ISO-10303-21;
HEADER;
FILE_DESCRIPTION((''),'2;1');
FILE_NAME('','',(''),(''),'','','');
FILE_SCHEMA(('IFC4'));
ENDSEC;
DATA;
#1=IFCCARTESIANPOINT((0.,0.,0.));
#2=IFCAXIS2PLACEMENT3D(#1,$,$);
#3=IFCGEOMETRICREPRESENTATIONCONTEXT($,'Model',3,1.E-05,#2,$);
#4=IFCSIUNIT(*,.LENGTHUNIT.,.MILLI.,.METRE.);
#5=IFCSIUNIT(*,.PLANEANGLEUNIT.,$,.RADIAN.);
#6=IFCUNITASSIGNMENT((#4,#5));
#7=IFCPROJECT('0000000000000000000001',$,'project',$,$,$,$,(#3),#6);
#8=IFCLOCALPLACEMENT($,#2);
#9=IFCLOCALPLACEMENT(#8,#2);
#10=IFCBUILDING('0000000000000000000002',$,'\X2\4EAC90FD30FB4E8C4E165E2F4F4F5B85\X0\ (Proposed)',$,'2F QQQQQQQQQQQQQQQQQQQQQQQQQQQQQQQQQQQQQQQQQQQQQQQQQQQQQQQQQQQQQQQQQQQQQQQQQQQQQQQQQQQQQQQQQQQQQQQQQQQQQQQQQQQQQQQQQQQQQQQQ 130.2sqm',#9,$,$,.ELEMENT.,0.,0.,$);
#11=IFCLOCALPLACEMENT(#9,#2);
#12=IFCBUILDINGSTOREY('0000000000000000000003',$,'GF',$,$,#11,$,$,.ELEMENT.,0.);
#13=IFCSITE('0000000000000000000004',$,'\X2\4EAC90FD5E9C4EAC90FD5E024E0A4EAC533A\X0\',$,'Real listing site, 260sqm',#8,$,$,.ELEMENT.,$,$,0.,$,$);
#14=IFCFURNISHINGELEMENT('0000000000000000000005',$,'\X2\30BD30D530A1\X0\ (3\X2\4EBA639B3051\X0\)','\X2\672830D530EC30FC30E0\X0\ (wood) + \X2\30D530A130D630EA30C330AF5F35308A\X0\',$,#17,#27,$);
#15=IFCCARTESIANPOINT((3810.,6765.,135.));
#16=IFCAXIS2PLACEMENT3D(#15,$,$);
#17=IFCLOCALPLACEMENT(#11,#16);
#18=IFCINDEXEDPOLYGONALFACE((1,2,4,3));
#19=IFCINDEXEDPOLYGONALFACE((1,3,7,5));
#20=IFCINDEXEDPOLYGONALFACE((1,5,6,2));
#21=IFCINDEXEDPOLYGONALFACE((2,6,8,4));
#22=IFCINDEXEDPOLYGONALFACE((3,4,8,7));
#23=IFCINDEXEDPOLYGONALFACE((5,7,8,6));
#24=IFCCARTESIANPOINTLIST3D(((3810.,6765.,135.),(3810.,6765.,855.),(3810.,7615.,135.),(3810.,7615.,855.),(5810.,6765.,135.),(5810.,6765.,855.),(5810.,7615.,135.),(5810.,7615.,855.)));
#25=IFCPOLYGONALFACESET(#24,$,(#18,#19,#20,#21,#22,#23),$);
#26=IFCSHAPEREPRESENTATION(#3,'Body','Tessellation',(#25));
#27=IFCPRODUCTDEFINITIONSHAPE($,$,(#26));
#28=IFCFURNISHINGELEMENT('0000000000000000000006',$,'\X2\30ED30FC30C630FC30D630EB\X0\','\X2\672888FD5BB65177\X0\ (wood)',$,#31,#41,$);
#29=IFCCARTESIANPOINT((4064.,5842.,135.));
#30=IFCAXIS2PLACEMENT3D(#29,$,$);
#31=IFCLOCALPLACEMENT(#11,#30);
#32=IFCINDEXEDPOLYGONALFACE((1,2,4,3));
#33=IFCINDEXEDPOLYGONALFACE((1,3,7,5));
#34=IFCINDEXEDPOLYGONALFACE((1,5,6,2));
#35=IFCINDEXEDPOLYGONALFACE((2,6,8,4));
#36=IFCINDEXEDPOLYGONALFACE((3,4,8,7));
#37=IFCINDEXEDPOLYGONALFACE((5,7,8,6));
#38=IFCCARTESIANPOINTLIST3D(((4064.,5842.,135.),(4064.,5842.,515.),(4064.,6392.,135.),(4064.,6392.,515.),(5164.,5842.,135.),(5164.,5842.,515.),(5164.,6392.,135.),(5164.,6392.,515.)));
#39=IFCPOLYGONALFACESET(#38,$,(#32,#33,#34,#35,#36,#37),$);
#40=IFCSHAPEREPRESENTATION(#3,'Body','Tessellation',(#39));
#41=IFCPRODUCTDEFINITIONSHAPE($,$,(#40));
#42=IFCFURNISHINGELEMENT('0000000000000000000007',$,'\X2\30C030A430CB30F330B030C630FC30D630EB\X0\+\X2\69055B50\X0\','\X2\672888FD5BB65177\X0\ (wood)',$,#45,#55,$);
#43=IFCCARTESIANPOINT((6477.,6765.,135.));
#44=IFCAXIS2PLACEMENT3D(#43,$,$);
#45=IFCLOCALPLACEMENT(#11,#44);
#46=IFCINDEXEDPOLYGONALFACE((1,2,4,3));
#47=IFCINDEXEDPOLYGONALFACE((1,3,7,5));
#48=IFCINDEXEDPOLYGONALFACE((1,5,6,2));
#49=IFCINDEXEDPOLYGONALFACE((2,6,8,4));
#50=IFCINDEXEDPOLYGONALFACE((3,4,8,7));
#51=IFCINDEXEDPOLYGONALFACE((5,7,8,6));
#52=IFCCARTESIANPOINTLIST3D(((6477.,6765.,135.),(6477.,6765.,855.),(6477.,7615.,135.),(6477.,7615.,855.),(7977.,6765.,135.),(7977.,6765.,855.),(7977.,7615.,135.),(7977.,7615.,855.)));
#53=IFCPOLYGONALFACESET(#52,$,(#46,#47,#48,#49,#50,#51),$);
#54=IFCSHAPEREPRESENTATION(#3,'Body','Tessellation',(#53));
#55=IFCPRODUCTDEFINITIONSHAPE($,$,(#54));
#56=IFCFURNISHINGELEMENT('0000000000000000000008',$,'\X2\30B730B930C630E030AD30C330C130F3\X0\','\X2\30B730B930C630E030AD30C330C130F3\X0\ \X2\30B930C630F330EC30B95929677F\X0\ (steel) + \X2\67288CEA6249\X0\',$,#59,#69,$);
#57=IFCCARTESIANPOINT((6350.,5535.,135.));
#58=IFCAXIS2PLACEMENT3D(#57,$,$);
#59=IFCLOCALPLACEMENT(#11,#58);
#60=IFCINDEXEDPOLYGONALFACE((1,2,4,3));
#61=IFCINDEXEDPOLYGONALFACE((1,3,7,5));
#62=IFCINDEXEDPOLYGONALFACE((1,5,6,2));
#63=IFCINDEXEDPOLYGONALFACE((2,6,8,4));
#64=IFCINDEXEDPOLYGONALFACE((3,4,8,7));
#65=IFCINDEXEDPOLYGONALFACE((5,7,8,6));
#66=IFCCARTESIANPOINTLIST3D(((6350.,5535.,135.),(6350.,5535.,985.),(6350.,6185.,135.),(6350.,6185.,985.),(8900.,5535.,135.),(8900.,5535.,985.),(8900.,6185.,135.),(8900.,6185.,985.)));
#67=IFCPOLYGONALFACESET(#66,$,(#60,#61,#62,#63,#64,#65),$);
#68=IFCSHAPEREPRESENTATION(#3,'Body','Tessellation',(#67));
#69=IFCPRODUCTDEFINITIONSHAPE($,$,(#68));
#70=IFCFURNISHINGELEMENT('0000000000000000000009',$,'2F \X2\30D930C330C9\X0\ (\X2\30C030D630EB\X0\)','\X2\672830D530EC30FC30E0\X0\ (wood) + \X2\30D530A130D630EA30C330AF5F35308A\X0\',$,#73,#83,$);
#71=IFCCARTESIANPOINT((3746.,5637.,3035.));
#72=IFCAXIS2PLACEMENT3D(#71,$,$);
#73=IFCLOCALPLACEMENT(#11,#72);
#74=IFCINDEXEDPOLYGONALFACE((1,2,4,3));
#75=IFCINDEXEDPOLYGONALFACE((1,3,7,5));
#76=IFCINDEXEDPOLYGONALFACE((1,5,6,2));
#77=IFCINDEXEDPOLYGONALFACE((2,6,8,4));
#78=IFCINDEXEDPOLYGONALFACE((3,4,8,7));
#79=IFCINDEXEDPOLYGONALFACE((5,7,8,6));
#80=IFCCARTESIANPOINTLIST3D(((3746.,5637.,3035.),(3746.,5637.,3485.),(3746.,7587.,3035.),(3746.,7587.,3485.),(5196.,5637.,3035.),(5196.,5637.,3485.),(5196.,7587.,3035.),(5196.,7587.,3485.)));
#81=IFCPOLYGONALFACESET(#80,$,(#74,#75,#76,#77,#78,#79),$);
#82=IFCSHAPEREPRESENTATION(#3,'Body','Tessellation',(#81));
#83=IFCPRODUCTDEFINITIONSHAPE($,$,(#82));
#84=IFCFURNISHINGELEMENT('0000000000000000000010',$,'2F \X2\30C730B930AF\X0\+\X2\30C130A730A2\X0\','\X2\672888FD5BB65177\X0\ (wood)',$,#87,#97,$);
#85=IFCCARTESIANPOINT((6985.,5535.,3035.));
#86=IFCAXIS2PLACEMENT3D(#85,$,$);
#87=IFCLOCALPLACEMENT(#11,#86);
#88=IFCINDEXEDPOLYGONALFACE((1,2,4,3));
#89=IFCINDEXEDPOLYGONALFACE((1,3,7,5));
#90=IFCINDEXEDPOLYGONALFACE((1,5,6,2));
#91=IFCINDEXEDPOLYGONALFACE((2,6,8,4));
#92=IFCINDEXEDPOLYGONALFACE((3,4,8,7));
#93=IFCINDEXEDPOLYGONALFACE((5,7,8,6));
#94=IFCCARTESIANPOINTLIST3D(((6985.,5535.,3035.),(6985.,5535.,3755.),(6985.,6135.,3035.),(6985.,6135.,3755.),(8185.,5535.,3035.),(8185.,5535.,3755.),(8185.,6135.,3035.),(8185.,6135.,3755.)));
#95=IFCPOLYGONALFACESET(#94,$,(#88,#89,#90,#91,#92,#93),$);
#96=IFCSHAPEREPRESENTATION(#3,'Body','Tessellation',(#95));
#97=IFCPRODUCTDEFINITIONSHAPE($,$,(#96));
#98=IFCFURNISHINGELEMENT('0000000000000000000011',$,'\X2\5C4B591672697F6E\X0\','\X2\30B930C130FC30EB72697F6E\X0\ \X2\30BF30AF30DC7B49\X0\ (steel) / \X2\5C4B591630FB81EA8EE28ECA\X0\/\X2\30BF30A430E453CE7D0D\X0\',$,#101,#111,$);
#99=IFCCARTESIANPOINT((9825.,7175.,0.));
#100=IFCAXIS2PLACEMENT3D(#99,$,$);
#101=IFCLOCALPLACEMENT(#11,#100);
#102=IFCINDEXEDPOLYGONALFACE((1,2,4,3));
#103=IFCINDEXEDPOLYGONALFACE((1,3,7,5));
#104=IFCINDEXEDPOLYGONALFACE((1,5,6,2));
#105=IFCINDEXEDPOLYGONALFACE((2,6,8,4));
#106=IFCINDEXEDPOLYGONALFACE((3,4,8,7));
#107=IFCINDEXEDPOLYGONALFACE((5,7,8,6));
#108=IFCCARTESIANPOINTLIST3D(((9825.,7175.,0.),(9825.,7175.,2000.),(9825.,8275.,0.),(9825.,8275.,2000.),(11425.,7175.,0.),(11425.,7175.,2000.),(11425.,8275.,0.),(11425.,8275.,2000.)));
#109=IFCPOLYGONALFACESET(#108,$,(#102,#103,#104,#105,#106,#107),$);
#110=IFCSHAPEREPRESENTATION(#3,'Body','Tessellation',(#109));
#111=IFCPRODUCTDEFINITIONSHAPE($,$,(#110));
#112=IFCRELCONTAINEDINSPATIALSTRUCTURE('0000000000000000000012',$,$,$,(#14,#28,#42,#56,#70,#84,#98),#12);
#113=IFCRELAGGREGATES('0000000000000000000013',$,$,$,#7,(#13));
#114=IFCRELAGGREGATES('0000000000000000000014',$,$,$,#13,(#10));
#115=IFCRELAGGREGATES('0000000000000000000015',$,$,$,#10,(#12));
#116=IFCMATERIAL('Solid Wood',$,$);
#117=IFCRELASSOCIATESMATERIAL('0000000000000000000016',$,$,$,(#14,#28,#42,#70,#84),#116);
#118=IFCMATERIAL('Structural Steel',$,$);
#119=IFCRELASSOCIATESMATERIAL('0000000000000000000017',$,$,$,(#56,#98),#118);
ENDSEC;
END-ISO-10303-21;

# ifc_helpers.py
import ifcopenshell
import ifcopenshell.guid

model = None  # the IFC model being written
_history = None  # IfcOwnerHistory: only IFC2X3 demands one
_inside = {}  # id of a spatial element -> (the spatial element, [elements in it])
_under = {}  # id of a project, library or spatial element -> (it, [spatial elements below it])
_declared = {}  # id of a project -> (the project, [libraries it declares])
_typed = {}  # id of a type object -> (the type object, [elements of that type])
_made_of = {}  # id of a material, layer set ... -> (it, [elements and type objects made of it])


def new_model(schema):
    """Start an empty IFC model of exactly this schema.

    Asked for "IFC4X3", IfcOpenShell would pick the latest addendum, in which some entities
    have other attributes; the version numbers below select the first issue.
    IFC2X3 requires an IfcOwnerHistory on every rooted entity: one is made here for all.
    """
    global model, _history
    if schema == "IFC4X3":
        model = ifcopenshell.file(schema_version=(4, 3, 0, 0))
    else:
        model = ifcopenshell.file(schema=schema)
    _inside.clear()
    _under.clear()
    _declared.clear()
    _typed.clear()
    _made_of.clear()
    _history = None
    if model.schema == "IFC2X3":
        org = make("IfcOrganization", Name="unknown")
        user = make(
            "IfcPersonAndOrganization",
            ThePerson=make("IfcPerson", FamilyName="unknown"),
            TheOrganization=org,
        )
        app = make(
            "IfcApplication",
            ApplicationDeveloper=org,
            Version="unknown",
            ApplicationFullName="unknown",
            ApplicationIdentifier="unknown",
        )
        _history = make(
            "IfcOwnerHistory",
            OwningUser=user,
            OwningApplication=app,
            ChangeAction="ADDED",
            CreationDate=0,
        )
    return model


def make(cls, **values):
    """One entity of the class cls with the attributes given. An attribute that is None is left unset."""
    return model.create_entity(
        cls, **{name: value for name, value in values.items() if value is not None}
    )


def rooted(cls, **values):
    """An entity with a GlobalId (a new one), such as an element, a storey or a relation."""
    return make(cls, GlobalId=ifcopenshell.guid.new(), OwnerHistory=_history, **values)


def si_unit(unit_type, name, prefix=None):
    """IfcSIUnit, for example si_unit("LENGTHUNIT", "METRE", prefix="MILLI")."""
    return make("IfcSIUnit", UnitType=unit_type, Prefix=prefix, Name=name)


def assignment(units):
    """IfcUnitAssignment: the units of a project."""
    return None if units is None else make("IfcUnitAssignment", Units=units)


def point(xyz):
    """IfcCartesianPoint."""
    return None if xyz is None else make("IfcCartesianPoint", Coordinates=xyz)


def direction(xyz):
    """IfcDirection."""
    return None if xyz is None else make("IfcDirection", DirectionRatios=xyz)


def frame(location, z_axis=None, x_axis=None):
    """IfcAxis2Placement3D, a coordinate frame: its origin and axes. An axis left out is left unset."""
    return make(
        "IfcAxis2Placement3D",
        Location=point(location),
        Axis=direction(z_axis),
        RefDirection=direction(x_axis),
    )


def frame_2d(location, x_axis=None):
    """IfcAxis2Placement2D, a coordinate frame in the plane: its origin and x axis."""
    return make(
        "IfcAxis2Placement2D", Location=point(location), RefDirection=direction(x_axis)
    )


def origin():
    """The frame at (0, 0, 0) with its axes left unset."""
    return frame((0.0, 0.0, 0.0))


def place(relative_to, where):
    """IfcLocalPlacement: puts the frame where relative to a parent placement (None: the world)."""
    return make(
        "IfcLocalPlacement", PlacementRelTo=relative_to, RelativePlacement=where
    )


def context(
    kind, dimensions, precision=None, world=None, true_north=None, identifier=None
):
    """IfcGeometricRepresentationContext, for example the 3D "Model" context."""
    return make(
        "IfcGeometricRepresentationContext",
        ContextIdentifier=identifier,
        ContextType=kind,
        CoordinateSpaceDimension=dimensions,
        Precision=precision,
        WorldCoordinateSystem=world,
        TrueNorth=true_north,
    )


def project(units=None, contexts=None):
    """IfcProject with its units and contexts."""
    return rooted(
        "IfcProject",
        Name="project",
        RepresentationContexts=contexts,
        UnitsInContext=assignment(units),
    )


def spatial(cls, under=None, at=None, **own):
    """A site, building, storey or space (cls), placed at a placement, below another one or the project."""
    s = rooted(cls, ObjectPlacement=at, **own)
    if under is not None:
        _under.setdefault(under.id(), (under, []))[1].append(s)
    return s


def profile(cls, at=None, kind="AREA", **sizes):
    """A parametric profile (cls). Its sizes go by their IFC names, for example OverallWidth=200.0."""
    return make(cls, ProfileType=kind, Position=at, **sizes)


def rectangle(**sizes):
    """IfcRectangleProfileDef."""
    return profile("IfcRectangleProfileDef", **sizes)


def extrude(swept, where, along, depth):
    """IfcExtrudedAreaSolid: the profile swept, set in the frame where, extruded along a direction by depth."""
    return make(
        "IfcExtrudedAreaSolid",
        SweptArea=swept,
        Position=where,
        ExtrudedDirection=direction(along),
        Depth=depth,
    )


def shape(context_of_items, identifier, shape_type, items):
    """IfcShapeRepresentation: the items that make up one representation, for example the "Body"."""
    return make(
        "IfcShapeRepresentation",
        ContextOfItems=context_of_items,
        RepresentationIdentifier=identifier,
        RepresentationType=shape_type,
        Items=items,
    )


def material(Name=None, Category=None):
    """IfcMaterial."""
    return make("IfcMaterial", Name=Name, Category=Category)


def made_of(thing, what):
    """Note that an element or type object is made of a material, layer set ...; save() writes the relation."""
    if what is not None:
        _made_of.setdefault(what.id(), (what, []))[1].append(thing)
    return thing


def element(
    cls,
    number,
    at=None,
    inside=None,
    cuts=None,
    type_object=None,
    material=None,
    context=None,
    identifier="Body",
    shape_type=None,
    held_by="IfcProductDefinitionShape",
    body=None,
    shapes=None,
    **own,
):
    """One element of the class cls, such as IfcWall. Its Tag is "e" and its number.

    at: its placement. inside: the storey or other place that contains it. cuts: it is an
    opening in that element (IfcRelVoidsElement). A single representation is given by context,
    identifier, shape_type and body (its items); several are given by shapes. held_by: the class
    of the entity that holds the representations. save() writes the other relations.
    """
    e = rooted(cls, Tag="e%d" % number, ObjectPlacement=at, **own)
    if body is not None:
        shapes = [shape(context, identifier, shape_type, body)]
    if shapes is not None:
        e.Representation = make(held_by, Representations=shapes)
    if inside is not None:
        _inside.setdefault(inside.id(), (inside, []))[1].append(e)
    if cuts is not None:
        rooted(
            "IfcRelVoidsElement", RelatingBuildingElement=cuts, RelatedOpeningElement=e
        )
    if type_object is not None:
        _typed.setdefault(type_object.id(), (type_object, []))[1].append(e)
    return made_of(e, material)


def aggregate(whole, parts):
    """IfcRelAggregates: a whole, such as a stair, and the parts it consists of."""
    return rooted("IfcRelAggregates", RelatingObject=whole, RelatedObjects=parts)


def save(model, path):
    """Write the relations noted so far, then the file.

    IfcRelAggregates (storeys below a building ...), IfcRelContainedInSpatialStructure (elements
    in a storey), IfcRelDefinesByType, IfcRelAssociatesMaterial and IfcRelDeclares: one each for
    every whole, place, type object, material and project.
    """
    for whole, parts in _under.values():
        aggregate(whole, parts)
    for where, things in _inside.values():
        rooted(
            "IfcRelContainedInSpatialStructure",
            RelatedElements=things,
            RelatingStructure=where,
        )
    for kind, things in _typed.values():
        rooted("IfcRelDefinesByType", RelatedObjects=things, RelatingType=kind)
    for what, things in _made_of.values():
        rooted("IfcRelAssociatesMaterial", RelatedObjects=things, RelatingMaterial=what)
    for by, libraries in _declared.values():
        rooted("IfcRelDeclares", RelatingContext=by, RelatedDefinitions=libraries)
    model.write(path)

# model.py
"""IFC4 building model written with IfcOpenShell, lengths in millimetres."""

from ifc_helpers import new_model, si_unit, frame, frame_2d, origin, place, context, project, spatial, rectangle, extrude, material, element, save


model = new_model("IFC4")

# Units and contexts
model_context = context("Model", 3, precision=1e-05, world=origin())
ifc_project = project(units=[si_unit("LENGTHUNIT", "METRE", prefix="MILLI"), si_unit("PLANEANGLEUNIT", "RADIAN")], contexts=[model_context])

# Site, building, storey
site_placement = place(None, origin())
site = spatial("IfcSite", under=ifc_project, at=site_placement, Name="京都府京都市上京区", ObjectType="Real listing site, 260sqm", CompositionType="ELEMENT", RefElevation=0.0)
building_placement = place(site_placement, origin())
building = spatial("IfcBuilding", under=site, at=building_placement, Name="京都・二世帯住宅 (Proposed)", ObjectType="2F QQQQQQQQQQQQQQQQQQQQQQQQQQQQQQQQQQQQQQQQQQQQQQQQQQQQQQQQQQQQQQQQQQQQQQQQQQQQQQQQQQQQQQQQQQQQQQQQQQQQQQQQQQQQQQQQQQQQQQQQ 130.2sqm", CompositionType="ELEMENT", ElevationOfRefHeight=0.0, ElevationOfTerrain=0.0)
storey_placement = place(building_placement, origin())
storey = spatial("IfcBuildingStorey", under=building, at=storey_placement, Name="GF", CompositionType="ELEMENT", Elevation=0.0)

# Shared definitions
ifc_material_1 = material(Name="Solid Wood")

# Shared definitions
ifc_material_2 = material(Name="Structural Steel")

# Furnishing elements
furnishing_1_placement = place(storey_placement, frame((3810.0, 6765.0, 135.0)))
element("IfcFurnishingElement", 1, at=furnishing_1_placement, inside=storey, material=ifc_material_1, Name="ソファ (3人掛け)", Description="木フレーム (wood) + ファブリック張り", context=model_context, shape_type="SweptSolid", body=[
    extrude(rectangle(XDim=2000.0, YDim=850.0, at=frame_2d((1000.0, 425.0))), frame((3810.0, 6765.0, 135.0)), (0.0, 0.0, 1.0), 720.0),
])
furnishing_2_placement = place(storey_placement, frame((4064.0, 5842.0, 135.0)))
element("IfcFurnishingElement", 2, at=furnishing_2_placement, inside=storey, material=ifc_material_1, Name="ローテーブル", Description="木製家具 (wood)", context=model_context, shape_type="SweptSolid", body=[
    extrude(rectangle(XDim=1100.0, YDim=550.0, at=frame_2d((550.0, 275.0))), frame((4064.0, 5842.0, 135.0)), (0.0, 0.0, 1.0), 380.0),
])
furnishing_3_placement = place(storey_placement, frame((6477.0, 6765.0, 135.0)))
element("IfcFurnishingElement", 3, at=furnishing_3_placement, inside=storey, material=ifc_material_1, Name="ダイニングテーブル+椅子", Description="木製家具 (wood)", context=model_context, shape_type="SweptSolid", body=[
    extrude(rectangle(XDim=1500.0, YDim=850.0, at=frame_2d((750.0, 425.0))), frame((6477.0, 6765.0, 135.0)), (0.0, 0.0, 1.0), 720.0),
])
furnishing_4_placement = place(storey_placement, frame((6350.0, 5535.0, 135.0)))
element("IfcFurnishingElement", 4, at=furnishing_4_placement, inside=storey, material=ifc_material_2, Name="システムキッチン", Description="システムキッチン ステンレス天板 (steel) + 木質扉", context=model_context, shape_type="SweptSolid", body=[
    extrude(rectangle(XDim=2550.0, YDim=650.0, at=frame_2d((1275.0, 325.0))), frame((6350.0, 5535.0, 135.0)), (0.0, 0.0, 1.0), 850.0),
])
furnishing_5_placement = place(storey_placement, frame((3746.0, 5637.0, 3035.0)))
element("IfcFurnishingElement", 5, at=furnishing_5_placement, inside=storey, material=ifc_material_1, Name="2F ベッド (ダブル)", Description="木フレーム (wood) + ファブリック張り", context=model_context, shape_type="SweptSolid", body=[
    extrude(rectangle(XDim=1450.0, YDim=1950.0, at=frame_2d((725.0, 975.0))), frame((3746.0, 5637.0, 3035.0)), (0.0, 0.0, 1.0), 450.0),
])
furnishing_6_placement = place(storey_placement, frame((6985.0, 5535.0, 3035.0)))
element("IfcFurnishingElement", 6, at=furnishing_6_placement, inside=storey, material=ifc_material_1, Name="2F デスク+チェア", Description="木製家具 (wood)", context=model_context, shape_type="SweptSolid", body=[
    extrude(rectangle(XDim=1200.0, YDim=600.0, at=frame_2d((600.0, 300.0))), frame((6985.0, 5535.0, 3035.0)), (0.0, 0.0, 1.0), 720.0),
])
furnishing_7_placement = place(storey_placement, frame((9825.0, 7175.0, 0.0)))
element("IfcFurnishingElement", 7, at=furnishing_7_placement, inside=storey, material=ifc_material_2, Name="屋外物置", Description="スチール物置 タクボ等 (steel) / 屋外・自転車/タイヤ収納", context=model_context, shape_type="SweptSolid", body=[
    extrude(rectangle(XDim=1600.0, YDim=1100.0, at=frame_2d((800.0, 550.0))), frame((9825.0, 7175.0, 0.0)), (0.0, 0.0, 1.0), 2000.0),
])

save(model, "model.ifc")
